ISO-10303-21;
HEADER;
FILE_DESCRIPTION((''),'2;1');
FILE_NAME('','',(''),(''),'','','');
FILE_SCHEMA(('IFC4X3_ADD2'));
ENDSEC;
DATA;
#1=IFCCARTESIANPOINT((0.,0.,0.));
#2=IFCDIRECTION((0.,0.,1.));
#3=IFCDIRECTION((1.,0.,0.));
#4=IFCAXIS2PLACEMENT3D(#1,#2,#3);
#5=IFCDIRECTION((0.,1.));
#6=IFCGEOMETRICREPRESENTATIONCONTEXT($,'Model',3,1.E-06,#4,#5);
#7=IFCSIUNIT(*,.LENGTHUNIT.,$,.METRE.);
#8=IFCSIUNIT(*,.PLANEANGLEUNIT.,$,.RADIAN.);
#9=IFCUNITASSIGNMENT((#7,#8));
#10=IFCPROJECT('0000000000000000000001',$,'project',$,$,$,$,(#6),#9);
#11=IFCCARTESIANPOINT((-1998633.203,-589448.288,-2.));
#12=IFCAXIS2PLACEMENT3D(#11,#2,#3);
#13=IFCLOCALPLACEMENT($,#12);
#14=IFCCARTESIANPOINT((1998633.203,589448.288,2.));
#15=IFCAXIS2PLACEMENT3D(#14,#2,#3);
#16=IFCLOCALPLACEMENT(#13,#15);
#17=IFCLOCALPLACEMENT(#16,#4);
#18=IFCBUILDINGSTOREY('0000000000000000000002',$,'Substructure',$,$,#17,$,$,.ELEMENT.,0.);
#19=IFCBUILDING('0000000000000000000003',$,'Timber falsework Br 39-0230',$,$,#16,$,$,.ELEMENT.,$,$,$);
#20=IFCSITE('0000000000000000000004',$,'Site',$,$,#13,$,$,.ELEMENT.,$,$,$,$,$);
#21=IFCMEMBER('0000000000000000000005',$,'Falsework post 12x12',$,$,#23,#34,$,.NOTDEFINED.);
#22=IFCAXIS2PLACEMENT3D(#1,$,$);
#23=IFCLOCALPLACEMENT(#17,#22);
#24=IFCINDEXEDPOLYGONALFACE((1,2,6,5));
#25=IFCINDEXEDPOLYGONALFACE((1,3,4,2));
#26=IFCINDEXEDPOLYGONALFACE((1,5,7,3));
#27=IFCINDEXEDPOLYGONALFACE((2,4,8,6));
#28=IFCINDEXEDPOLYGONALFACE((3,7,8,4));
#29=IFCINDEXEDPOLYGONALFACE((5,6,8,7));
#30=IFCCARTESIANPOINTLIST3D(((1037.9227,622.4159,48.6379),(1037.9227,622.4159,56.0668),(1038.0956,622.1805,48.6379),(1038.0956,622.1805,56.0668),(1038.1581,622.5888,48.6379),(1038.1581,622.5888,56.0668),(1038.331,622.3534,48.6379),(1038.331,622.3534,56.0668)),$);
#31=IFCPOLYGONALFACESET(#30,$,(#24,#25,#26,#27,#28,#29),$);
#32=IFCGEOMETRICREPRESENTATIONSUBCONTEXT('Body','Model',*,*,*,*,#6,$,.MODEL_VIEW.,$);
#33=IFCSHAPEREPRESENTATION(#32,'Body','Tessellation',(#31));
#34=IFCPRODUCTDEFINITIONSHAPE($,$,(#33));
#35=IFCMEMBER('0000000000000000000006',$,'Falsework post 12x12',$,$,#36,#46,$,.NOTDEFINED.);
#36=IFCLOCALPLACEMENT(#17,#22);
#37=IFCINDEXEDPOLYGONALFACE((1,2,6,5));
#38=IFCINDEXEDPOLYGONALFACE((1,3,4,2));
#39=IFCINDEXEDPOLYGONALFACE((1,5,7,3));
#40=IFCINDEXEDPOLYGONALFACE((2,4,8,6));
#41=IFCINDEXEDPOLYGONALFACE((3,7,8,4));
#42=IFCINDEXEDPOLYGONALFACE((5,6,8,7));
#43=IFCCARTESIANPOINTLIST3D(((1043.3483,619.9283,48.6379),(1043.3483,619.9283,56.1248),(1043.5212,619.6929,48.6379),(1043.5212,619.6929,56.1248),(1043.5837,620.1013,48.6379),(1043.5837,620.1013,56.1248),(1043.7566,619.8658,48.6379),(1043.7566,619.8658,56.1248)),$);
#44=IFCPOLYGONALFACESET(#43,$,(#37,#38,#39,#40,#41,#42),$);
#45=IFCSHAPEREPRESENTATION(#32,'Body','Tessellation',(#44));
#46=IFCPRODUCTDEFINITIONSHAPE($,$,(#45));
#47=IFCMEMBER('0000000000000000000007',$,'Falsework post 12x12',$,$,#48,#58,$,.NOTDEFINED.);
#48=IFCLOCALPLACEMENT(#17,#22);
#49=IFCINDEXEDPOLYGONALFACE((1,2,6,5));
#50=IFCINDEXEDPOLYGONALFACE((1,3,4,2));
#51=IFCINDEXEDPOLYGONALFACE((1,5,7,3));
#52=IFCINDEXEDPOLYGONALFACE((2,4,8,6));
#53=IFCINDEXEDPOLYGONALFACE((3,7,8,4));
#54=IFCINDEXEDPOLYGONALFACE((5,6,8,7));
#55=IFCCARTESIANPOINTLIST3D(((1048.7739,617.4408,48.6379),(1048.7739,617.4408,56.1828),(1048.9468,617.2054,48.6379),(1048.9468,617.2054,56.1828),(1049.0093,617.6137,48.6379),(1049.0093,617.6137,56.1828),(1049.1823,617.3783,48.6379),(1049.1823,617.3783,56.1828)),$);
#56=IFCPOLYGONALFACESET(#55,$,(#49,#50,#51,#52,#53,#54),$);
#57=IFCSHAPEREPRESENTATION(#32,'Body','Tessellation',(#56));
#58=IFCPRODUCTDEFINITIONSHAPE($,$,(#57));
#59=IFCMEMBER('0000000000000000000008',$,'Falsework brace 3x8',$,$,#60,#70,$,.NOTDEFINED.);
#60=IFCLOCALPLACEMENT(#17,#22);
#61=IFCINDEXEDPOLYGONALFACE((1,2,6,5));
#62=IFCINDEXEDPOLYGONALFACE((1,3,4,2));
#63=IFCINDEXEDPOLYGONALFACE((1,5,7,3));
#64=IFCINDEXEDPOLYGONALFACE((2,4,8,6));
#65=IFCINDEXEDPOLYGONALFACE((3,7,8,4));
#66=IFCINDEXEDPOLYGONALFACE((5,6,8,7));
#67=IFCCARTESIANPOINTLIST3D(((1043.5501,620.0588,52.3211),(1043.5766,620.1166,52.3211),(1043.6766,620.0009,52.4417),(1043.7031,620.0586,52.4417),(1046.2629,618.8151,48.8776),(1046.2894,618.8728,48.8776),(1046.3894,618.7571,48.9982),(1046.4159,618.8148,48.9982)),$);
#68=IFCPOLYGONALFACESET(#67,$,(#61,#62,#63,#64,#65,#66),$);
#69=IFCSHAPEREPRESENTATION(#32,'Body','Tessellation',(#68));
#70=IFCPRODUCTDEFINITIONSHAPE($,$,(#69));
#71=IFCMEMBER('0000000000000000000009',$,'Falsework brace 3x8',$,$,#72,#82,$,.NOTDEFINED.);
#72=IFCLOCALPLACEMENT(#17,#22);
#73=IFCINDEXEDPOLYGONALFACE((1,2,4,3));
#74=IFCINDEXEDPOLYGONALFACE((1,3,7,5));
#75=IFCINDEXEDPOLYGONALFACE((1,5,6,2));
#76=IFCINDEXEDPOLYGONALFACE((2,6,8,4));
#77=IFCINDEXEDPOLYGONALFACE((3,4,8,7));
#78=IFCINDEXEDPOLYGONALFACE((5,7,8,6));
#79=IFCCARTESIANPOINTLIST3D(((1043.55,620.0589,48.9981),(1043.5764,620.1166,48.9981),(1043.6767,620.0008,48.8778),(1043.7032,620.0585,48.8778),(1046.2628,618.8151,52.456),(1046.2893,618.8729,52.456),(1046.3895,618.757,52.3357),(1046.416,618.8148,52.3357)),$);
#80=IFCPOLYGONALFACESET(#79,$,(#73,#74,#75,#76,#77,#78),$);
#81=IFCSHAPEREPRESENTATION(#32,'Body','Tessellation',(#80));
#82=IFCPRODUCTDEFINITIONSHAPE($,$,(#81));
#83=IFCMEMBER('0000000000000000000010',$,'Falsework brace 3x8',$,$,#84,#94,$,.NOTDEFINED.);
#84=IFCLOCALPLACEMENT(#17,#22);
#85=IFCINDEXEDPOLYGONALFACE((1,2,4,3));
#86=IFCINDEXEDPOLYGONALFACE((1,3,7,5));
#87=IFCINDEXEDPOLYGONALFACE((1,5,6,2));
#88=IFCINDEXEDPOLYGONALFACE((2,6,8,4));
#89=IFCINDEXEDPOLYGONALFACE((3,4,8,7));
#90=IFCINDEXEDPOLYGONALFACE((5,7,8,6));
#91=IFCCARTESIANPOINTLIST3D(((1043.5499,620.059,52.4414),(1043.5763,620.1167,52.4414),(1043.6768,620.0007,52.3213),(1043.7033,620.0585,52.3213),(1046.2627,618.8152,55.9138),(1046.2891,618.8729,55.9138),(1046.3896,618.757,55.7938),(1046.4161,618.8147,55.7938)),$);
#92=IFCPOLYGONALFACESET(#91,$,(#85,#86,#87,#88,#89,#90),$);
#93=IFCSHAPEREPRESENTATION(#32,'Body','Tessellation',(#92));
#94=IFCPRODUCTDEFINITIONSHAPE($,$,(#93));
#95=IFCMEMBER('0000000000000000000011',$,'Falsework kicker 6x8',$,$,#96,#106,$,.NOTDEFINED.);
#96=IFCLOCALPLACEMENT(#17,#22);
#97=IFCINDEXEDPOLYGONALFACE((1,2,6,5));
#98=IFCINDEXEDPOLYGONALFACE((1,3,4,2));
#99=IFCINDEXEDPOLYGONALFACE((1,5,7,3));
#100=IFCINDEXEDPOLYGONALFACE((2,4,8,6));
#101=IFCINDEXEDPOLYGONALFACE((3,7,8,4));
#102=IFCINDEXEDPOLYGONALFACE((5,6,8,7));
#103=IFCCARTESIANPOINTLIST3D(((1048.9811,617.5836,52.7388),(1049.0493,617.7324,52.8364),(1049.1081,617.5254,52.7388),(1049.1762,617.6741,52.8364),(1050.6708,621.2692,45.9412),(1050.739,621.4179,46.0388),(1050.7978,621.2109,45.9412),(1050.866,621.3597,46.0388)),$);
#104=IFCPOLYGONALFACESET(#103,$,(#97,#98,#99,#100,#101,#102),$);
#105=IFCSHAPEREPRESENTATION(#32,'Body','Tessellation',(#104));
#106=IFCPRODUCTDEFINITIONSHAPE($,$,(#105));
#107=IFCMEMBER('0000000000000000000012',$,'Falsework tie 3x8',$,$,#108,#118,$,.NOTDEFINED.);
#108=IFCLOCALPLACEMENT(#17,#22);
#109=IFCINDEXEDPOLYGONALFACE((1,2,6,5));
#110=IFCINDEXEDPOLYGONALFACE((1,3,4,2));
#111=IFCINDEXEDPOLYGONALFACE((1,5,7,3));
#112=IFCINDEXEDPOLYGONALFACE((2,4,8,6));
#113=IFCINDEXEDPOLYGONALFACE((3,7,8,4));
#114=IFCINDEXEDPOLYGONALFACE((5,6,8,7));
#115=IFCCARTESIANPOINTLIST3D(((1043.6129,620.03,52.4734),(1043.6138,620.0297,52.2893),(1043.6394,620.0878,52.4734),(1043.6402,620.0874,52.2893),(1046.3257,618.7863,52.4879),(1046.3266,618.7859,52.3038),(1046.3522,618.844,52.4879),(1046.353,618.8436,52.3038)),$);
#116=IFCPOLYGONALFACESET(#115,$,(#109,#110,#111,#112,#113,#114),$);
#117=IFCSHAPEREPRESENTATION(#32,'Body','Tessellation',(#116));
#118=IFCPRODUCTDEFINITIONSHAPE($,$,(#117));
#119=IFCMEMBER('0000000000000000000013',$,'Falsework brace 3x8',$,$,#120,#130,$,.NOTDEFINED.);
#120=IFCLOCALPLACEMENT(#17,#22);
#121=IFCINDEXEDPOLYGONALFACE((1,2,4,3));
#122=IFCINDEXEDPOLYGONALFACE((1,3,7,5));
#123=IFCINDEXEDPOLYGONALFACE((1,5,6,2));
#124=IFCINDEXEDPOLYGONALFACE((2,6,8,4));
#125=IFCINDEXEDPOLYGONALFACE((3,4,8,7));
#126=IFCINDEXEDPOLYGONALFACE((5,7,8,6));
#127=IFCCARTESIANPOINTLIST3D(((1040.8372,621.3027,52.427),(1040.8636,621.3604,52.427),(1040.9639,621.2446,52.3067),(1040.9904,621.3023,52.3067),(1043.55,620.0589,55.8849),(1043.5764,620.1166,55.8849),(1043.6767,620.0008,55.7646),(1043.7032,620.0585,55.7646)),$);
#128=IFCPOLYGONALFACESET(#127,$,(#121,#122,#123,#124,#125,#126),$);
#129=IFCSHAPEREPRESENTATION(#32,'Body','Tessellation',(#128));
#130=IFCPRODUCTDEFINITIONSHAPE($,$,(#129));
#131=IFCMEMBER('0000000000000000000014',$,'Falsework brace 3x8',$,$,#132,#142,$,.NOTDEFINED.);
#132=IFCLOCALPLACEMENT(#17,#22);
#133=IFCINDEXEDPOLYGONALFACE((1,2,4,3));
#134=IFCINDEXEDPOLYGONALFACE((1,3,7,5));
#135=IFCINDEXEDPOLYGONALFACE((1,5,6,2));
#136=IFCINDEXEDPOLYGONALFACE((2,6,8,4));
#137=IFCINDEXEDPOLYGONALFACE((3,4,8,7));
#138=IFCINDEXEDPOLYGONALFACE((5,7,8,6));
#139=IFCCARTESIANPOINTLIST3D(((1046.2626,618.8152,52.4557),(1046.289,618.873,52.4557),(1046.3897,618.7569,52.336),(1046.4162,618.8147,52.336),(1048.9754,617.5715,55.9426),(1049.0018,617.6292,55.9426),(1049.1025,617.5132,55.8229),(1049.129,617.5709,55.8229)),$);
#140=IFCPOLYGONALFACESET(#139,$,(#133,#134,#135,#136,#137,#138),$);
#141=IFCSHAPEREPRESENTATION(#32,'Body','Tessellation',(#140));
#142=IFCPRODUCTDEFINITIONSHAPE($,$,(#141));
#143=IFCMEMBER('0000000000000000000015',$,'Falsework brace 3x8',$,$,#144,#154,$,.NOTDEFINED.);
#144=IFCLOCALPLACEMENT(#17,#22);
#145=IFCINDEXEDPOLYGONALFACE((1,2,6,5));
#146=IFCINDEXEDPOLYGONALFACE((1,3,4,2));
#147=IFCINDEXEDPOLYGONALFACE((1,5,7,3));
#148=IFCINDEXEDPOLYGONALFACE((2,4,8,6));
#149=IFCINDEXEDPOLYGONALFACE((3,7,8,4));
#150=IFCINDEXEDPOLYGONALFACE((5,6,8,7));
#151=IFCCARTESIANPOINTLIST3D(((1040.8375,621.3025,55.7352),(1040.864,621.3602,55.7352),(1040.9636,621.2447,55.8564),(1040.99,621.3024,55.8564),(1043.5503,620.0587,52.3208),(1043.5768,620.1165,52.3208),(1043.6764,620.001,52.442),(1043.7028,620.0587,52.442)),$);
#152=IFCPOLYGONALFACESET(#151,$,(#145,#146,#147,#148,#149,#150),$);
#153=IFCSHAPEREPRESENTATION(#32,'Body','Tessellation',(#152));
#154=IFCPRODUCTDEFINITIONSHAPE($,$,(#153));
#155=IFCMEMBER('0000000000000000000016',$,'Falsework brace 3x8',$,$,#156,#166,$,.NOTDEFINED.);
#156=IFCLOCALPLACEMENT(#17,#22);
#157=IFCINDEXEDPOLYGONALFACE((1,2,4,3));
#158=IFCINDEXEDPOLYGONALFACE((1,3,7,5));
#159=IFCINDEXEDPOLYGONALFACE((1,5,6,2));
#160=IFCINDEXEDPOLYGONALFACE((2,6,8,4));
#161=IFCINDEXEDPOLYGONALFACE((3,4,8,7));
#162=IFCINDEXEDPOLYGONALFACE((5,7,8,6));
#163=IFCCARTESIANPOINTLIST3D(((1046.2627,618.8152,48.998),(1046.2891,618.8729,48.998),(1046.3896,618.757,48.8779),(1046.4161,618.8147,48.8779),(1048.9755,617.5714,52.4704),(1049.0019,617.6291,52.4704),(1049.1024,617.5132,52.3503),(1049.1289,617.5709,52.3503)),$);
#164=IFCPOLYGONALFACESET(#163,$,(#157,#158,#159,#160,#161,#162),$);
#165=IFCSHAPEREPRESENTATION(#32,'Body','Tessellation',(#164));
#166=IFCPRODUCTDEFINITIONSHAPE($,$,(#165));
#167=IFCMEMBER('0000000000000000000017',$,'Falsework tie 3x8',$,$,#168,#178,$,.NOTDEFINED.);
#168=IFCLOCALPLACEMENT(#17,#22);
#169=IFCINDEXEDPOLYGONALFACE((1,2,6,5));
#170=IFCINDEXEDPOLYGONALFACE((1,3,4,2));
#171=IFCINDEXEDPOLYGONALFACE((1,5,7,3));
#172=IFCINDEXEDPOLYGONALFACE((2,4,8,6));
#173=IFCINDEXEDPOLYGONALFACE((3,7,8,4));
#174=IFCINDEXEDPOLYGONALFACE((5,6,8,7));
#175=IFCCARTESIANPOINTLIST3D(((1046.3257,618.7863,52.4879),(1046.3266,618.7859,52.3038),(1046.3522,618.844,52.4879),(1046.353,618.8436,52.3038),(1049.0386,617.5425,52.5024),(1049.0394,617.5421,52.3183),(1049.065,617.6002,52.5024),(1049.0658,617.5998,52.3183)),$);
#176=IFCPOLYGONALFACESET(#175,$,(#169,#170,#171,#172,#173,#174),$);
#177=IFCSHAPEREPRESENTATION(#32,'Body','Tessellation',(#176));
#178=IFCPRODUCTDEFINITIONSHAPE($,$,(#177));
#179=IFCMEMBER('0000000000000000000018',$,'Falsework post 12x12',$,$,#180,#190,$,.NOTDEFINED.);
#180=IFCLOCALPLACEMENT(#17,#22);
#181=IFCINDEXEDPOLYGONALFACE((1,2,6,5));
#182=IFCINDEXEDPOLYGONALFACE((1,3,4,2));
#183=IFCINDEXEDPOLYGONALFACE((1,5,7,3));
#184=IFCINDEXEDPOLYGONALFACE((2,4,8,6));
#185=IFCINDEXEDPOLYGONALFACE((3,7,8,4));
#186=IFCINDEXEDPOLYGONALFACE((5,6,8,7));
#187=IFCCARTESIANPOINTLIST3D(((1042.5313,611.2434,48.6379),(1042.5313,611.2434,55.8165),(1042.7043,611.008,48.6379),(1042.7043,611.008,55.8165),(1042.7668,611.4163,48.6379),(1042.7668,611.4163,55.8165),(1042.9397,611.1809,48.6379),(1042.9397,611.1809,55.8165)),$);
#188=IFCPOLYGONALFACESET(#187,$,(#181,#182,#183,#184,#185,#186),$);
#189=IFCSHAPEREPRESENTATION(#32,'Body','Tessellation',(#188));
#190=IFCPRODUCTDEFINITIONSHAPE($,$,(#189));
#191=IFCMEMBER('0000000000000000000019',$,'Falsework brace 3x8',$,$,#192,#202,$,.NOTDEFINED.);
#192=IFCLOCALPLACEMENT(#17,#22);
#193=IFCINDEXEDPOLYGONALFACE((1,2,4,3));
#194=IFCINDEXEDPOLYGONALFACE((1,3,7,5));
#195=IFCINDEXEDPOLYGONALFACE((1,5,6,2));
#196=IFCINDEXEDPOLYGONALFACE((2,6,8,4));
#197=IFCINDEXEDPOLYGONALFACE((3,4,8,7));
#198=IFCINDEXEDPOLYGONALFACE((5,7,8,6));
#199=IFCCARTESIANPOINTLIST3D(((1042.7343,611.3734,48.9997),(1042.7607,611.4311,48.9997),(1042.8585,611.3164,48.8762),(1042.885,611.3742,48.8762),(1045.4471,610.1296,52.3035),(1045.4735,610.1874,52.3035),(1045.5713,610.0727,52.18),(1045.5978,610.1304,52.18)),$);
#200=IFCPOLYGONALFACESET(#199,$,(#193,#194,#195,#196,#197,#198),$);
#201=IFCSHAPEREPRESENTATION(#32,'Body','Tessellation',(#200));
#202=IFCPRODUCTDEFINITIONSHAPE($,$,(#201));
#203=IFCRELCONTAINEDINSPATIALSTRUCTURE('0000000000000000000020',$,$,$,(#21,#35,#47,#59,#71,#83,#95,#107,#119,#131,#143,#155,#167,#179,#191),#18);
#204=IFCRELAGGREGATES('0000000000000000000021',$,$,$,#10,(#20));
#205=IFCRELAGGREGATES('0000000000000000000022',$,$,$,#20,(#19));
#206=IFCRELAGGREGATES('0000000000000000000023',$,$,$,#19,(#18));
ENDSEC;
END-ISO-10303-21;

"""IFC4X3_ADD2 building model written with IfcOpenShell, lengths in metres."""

from ifc_helpers import new_model, si_unit, direction, frame, origin, origin_with_axes, origin_2d, place, context, subcontext, project, spatial, rectangle, extrude, element, save


model = new_model("IFC4X3_ADD2")

# Units and contexts
model_context = context("Model", 3, precision=1e-06, world=origin_with_axes(), true_north=direction((0.0, 1.0)))
body_context = subcontext(model_context, "Body", "Model", "MODEL_VIEW")
ifc_project = project(units=[si_unit("LENGTHUNIT", "METRE"), si_unit("PLANEANGLEUNIT", "RADIAN")], contexts=[model_context])

# Site, building, storey
site_placement = place(None, frame((-1998633.203, -589448.288, -2.0), z_axis=(0.0, 0.0, 1.0), x_axis=(1.0, 0.0, 0.0)))
site = spatial("IfcSite", under=ifc_project, at=site_placement, Name="Site", CompositionType="ELEMENT")
building_placement = place(site_placement, frame((1998633.203, 589448.288, 2.0), z_axis=(0.0, 0.0, 1.0), x_axis=(1.0, 0.0, 0.0)))
building = spatial("IfcBuilding", under=site, at=building_placement, Name="Timber falsework Br 39-0230", CompositionType="ELEMENT")
storey_placement = place(building_placement, origin_with_axes())
storey = spatial("IfcBuildingStorey", under=building, at=storey_placement, Name="Substructure", CompositionType="ELEMENT", Elevation=0.0)

# Members
member_1_placement = place(storey_placement, frame((1038.1269, 622.3846, 48.6379), z_axis=(0.0, 0.0, 1.0), x_axis=(-0.805928, -0.592013, 0.0)))
element("IfcMember", 1, at=member_1_placement, inside=storey, Name="Falsework post 12x12", PredefinedType="NOTDEFINED", context=body_context, shape_type="SweptSolid", body=[
    extrude(rectangle(XDim=0.2921, YDim=0.2921, at=origin_2d()), origin(), (0.0, 0.0, 1.0), 7.4288),
])
member_2_placement = place(storey_placement, frame((1043.5525, 619.8971, 48.6379), z_axis=(0.0, 0.0, 1.0), x_axis=(-0.805928, -0.592013, 0.0)))
element("IfcMember", 2, at=member_2_placement, inside=storey, Name="Falsework post 12x12", PredefinedType="NOTDEFINED", context=body_context, shape_type="SweptSolid", body=[
    extrude(rectangle(XDim=0.2921, YDim=0.2921, at=origin_2d()), origin(), (0.0, 0.0, 1.0), 7.4868),
])
member_3_placement = place(storey_placement, frame((1048.9781, 617.4096, 48.6379), z_axis=(0.0, 0.0, 1.0), x_axis=(-0.805928, -0.592013, 0.0)))
element("IfcMember", 3, at=member_3_placement, inside=storey, Name="Falsework post 12x12", PredefinedType="NOTDEFINED", context=body_context, shape_type="SweptSolid", body=[
    extrude(rectangle(XDim=0.2921, YDim=0.2921, at=origin_2d()), origin(), (0.0, 0.0, 1.0), 7.5448),
])
member_4_placement = place(storey_placement, frame((1043.6266, 620.0587, 52.3814), z_axis=(0.595346, -0.272955, -0.755684), x_axis=(0.416765, 0.909014, 0.0)))
element("IfcMember", 4, at=member_4_placement, inside=storey, Name="Falsework brace 3x8", PredefinedType="NOTDEFINED", context=body_context, shape_type="SweptSolid", body=[
    extrude(rectangle(XDim=0.0635, YDim=0.1841, at=origin_2d()), origin(), (0.0, 0.0, 1.0), 4.5567),
])
member_5_placement = place(storey_placement, frame((1043.6266, 620.0587, 48.9379), z_axis=(0.593917, -0.272299, 0.757044), x_axis=(0.416765, 0.909014, 0.0)))
element("IfcMember", 5, at=member_5_placement, inside=storey, Name="Falsework brace 3x8", PredefinedType="NOTDEFINED", context=body_context, shape_type="SweptSolid", body=[
    extrude(rectangle(XDim=0.0635, YDim=0.1841, at=origin_2d()), origin(), (0.0, 0.0, 1.0), 4.5677),
])
member_6_placement = place(storey_placement, frame((1043.6266, 620.0587, 52.3814), z_axis=(0.592492, -0.271646, 0.758394), x_axis=(0.416765, 0.909014, 0.0)))
element("IfcMember", 6, at=member_6_placement, inside=storey, Name="Falsework brace 3x8", PredefinedType="NOTDEFINED", context=body_context, shape_type="SweptSolid", body=[
    extrude(rectangle(XDim=0.0635, YDim=0.1841, at=origin_2d()), origin(), (0.0, 0.0, 1.0), 4.5786),
])
member_7_placement = place(storey_placement, frame((1049.0787, 617.6289, 52.7876), z_axis=(0.213488, 0.465643, -0.858836), x_axis=(-0.909014, 0.416765, 0.0)))
element("IfcMember", 7, at=member_7_placement, inside=storey, Name="Falsework kicker 6x8", PredefinedType="NOTDEFINED", context=body_context, shape_type="SweptSolid", body=[
    extrude(rectangle(XDim=0.1397, YDim=0.1905, at=origin_2d()), origin(), (0.0, 0.0, 1.0), 7.9149),
])
member_8_placement = place(storey_placement, frame((1043.6266, 620.0587, 52.3814), z_axis=(0.909003, -0.41676, 0.004859), x_axis=(0.416765, 0.909014, 0.0)))
element("IfcMember", 8, at=member_8_placement, inside=storey, Name="Falsework tie 3x8", PredefinedType="NOTDEFINED", context=body_context, shape_type="SweptSolid", body=[
    extrude(rectangle(XDim=0.0635, YDim=0.1841, at=origin_2d()), origin(), (0.0, 0.0, 1.0), 2.9844),
])
member_9_placement = place(storey_placement, frame((1040.9138, 621.3025, 52.3669), z_axis=(0.593917, -0.272299, 0.757044), x_axis=(0.416765, 0.909014, 0.0)))
element("IfcMember", 9, at=member_9_placement, inside=storey, Name="Falsework brace 3x8", PredefinedType="NOTDEFINED", context=body_context, shape_type="SweptSolid", body=[
    extrude(rectangle(XDim=0.0635, YDim=0.1841, at=origin_2d()), origin(), (0.0, 0.0, 1.0), 4.5677),
])
member_10_placement = place(storey_placement, frame((1046.3394, 618.8149, 52.3959), z_axis=(0.591071, -0.270994, 0.759735), x_axis=(0.416765, 0.909014, 0.0)))
element("IfcMember", 10, at=member_10_placement, inside=storey, Name="Falsework brace 3x8", PredefinedType="NOTDEFINED", context=body_context, shape_type="SweptSolid", body=[
    extrude(rectangle(XDim=0.0635, YDim=0.1841, at=origin_2d()), origin(), (0.0, 0.0, 1.0), 4.5896),
])
member_11_placement = place(storey_placement, frame((1040.9138, 621.3025, 55.7958), z_axis=(0.598218, -0.274271, -0.752934), x_axis=(0.416765, 0.909014, 0.0)))
element("IfcMember", 11, at=member_11_placement, inside=storey, Name="Falsework brace 3x8", PredefinedType="NOTDEFINED", context=body_context, shape_type="SweptSolid", body=[
    extrude(rectangle(XDim=0.0635, YDim=0.1841, at=origin_2d()), origin(), (0.0, 0.0, 1.0), 4.5348),
])
member_12_placement = place(storey_placement, frame((1046.3394, 618.8149, 48.9379), z_axis=(0.592492, -0.271646, 0.758394), x_axis=(0.416765, 0.909014, 0.0)))
element("IfcMember", 12, at=member_12_placement, inside=storey, Name="Falsework brace 3x8", PredefinedType="NOTDEFINED", context=body_context, shape_type="SweptSolid", body=[
    extrude(rectangle(XDim=0.0635, YDim=0.1841, at=origin_2d()), origin(), (0.0, 0.0, 1.0), 4.5786),
])
member_13_placement = place(storey_placement, frame((1046.3394, 618.8149, 52.3959), z_axis=(0.909003, -0.41676, 0.004859), x_axis=(0.416765, 0.909014, 0.0)))
element("IfcMember", 13, at=member_13_placement, inside=storey, Name="Falsework tie 3x8", PredefinedType="NOTDEFINED", context=body_context, shape_type="SweptSolid", body=[
    extrude(rectangle(XDim=0.0635, YDim=0.1841, at=origin_2d()), origin(), (0.0, 0.0, 1.0), 2.9844),
])
member_14_placement = place(storey_placement, frame((1042.7355, 611.2122, 48.6379), z_axis=(0.0, 0.0, 1.0), x_axis=(-0.805928, -0.592013, 0.0)))
element("IfcMember", 14, at=member_14_placement, inside=storey, Name="Falsework post 12x12", PredefinedType="NOTDEFINED", context=body_context, shape_type="SweptSolid", body=[
    extrude(rectangle(XDim=0.2921, YDim=0.2921, at=origin_2d()), origin(), (0.0, 0.0, 1.0), 7.1786),
])
member_15_placement = place(storey_placement, frame((1042.8096, 611.3738, 48.9379), z_axis=(0.609329, -0.279365, 0.742073), x_axis=(0.416765, 0.909014, 0.0)))
element("IfcMember", 15, at=member_15_placement, inside=storey, Name="Falsework brace 3x8", PredefinedType="NOTDEFINED", context=body_context, shape_type="SweptSolid", body=[
    extrude(rectangle(XDim=0.0635, YDim=0.1841, at=origin_2d()), origin(), (0.0, 0.0, 1.0), 4.4521),
])

save(model, "model.ifc")
